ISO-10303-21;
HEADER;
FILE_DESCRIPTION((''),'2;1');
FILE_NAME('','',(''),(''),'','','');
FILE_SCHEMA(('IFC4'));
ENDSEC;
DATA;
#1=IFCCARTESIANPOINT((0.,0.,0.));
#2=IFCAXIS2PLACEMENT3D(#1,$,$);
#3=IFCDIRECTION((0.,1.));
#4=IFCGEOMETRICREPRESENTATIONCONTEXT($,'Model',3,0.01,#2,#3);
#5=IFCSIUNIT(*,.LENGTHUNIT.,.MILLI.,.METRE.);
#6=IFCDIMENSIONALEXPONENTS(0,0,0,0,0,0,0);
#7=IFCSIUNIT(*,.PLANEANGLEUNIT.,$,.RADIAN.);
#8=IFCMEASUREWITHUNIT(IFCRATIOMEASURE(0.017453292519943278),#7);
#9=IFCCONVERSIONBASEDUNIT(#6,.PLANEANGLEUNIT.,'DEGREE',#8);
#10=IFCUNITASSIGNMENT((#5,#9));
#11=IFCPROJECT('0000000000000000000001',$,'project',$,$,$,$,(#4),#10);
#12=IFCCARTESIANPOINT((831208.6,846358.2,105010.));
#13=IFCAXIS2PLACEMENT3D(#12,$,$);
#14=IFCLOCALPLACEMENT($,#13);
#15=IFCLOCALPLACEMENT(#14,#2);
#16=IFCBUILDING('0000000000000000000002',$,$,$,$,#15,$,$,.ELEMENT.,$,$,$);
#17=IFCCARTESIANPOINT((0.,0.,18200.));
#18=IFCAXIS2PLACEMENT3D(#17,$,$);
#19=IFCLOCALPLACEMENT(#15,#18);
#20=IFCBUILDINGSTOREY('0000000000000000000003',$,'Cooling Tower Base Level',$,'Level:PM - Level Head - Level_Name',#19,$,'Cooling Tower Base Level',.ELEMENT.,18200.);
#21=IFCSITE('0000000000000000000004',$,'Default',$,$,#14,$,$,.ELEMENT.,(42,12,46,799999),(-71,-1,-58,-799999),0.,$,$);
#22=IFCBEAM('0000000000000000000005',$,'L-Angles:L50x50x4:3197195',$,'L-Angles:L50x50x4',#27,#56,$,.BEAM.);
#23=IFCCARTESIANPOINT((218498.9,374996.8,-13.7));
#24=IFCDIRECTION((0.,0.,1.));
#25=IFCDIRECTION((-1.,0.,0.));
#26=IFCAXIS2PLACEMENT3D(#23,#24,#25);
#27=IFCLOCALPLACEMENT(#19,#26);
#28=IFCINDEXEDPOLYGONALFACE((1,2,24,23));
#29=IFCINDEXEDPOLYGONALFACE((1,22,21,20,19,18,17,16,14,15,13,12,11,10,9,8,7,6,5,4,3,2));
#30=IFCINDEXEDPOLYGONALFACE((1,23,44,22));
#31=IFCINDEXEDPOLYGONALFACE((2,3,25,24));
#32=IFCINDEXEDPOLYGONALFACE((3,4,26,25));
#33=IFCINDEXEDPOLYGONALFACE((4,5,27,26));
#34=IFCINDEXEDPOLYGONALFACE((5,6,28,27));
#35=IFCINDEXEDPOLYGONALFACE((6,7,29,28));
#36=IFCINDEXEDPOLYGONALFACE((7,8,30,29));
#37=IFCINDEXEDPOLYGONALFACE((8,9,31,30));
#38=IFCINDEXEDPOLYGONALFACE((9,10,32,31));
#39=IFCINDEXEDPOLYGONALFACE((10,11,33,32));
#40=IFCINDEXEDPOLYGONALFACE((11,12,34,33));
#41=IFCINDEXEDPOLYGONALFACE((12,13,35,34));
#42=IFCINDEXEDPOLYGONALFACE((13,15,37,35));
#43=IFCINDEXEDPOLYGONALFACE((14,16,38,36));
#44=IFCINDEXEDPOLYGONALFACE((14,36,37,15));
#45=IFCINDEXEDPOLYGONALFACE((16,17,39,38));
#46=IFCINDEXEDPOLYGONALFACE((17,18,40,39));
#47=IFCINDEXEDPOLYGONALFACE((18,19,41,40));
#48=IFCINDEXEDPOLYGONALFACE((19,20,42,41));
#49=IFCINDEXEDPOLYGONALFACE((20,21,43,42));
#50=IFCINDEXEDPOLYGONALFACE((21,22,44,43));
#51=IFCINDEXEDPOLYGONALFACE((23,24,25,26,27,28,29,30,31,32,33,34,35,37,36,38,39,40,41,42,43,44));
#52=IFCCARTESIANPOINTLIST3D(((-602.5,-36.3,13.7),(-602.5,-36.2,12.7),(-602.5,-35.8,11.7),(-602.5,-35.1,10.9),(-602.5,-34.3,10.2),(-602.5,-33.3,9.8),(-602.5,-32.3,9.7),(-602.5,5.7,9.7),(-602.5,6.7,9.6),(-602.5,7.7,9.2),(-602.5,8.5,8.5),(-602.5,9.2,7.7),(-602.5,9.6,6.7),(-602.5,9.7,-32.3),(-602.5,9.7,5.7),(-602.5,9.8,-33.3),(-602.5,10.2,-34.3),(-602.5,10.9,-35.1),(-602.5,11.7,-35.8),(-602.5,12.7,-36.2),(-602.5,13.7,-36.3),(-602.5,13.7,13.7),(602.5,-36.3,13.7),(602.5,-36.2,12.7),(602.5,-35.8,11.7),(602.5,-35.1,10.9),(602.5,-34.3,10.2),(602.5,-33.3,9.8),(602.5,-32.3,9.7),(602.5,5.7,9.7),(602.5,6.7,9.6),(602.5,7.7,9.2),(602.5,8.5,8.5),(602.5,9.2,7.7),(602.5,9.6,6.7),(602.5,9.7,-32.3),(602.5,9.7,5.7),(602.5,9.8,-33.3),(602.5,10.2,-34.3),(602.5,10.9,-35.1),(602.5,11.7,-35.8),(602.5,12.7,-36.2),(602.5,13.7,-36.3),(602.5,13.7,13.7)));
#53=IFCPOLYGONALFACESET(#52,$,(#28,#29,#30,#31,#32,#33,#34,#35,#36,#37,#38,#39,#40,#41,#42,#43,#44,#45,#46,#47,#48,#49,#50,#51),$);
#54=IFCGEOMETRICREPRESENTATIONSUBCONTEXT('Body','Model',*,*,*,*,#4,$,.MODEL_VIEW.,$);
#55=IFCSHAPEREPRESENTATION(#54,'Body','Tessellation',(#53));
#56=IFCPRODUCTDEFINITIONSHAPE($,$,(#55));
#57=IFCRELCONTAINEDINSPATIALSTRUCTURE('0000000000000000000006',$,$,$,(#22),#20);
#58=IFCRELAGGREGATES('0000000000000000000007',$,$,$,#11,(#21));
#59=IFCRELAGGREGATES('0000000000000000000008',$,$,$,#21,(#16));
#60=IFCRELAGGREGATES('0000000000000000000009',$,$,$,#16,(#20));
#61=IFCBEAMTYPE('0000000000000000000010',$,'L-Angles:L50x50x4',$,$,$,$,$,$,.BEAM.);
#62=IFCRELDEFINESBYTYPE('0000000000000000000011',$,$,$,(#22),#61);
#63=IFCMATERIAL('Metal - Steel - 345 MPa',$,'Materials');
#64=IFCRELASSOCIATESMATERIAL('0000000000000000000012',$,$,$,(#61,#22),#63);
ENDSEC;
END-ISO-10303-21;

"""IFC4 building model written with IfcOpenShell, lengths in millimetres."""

from ifc_helpers import new_model, entity, si_unit, converted_unit, direction, frame, origin, place, context, subcontext, project, spatial, line, arc, indexed_curve, outline, extrude, source, transform, mapped, material, type_object, type_shapes, element, save


model = new_model("IFC4")

# Units and contexts
model_context = context("Model", 3, precision=0.01, world=origin(), true_north=direction((0.0, 1.0)))
body_context = subcontext(model_context, "Body", "Model", "MODEL_VIEW")
ifc_project = project(units=[si_unit("LENGTHUNIT", "METRE", prefix="MILLI"), converted_unit("PLANEANGLEUNIT", "DEGREE", entity("IfcRatioMeasure", 0.017453292519943278), si_unit("PLANEANGLEUNIT", "RADIAN"), dimensions=[0, 0, 0, 0, 0, 0, 0])], contexts=[model_context])

# Site, building, storey
site_placement = place(None, frame((831208.6, 846358.2, 105010.0)))
site = spatial("IfcSite", under=ifc_project, at=site_placement, Name="Default", CompositionType="ELEMENT", RefLatitude=(42, 12, 46, 799999), RefLongitude=(-71, -1, -58, -799999), RefElevation=0.0)
building_placement = place(site_placement, origin())
building = spatial("IfcBuilding", under=site, at=building_placement, CompositionType="ELEMENT")
storey_placement = place(building_placement, frame((0.0, 0.0, 18200.0)))
storey = spatial("IfcBuildingStorey", under=building, at=storey_placement, Name="Cooling Tower Base Level", ObjectType="Level:PM - Level Head - Level_Name", LongName="Cooling Tower Base Level", CompositionType="ELEMENT", Elevation=18200.0)

# Beam
ifc_material = material(Name="Metal - Steel - 345 MPa", Category="Materials")
beam_type = type_object("IfcBeamType", Name="L-Angles:L50x50x4", PredefinedType="BEAM", material=ifc_material)
shared_shape = source(origin(), body_context, "Body", "SweptSolid", [
    extrude(outline(indexed_curve([(-34.0, -16.0), (16.0, -16.0), (16.0, 34.0), (13.2, 32.8), (12.0, 30.0), (12.0, -8.0), (10.8, -10.8), (8.0, -12.0), (-30.0, -12.0), (-32.8, -13.2)], segments=[line(1, 2, 3), arc(3, 4, 5), line(5, 6), arc(6, 7, 8), line(8, 9), arc(9, 10, 1)], self_intersect=False)), frame((-602.5, -2.3, -2.3), z_axis=(1.0, 0.0, 0.0), x_axis=(0.0, 0.0, 1.0)), (0.0, 0.0, 1.0), 1205.0),
])
type_shapes(beam_type, [shared_shape])
beam_placement = place(storey_placement, frame((218498.9, 374996.8, -13.7), z_axis=(0.0, 0.0, 1.0), x_axis=(-1.0, 0.0, 0.0)))
element("IfcBeam", 1, at=beam_placement, inside=storey, type_object=beam_type, material=ifc_material, Name="L-Angles:L50x50x4:3197195", ObjectType="L-Angles:L50x50x4", PredefinedType="BEAM", context=body_context, shape_type="MappedRepresentation", body=[
    mapped(shared_shape, transform((0.0, 0.0, 0.0), scale=1.0)),
])

save(model, "model.ifc")
